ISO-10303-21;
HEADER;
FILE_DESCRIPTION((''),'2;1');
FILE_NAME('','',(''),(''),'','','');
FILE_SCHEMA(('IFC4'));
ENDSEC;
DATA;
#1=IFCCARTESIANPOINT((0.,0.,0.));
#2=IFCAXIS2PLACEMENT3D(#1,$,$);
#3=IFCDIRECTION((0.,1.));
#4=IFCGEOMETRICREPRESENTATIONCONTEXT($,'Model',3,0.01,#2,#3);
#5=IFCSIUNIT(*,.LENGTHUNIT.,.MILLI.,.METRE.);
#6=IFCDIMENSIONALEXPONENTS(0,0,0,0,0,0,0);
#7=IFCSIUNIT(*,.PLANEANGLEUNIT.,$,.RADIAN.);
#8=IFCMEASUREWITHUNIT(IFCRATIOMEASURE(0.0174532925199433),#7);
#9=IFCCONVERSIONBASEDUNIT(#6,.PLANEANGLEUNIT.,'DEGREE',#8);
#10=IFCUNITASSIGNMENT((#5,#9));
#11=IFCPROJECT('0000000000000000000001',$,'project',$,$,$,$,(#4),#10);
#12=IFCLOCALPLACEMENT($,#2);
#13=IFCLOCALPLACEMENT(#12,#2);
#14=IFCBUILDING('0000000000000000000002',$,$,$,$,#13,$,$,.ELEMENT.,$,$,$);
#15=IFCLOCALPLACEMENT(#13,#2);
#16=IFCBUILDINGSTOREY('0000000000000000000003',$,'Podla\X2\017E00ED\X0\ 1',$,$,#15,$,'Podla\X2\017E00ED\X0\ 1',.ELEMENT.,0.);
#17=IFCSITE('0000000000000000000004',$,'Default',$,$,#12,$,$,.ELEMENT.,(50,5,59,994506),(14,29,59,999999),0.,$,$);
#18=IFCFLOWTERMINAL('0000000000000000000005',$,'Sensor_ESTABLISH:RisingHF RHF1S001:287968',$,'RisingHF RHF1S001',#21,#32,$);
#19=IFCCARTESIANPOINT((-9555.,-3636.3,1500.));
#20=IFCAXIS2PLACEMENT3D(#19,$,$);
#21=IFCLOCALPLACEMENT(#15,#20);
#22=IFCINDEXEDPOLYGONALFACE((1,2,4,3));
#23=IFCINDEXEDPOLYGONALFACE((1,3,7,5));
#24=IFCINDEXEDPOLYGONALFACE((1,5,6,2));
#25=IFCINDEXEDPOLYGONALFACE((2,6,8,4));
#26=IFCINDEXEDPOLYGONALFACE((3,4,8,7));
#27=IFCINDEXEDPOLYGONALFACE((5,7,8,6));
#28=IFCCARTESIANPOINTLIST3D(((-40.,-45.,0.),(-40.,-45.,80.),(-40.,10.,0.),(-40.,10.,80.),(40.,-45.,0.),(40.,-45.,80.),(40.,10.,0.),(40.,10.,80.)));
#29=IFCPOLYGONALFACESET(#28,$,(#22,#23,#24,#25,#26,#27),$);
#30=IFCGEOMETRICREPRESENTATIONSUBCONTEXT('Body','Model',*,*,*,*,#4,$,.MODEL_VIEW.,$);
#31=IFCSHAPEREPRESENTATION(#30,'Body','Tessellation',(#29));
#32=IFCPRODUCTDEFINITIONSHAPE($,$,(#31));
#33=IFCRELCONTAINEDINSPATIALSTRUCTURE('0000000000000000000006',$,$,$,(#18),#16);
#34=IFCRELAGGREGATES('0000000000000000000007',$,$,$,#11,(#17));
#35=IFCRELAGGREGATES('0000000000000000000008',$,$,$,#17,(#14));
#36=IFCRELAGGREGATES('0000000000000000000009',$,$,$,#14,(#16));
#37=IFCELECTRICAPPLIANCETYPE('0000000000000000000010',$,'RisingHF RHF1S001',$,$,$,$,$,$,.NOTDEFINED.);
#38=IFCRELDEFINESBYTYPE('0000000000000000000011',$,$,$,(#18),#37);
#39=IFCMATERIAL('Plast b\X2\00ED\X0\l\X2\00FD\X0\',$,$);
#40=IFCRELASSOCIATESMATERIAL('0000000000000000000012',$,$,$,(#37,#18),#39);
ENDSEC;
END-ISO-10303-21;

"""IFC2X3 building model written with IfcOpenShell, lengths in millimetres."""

from ifc_helpers import new_model, entity, si_unit, converted_unit, direction, frame, frame_2d, origin, place, context, subcontext, project, spatial, rectangle, extrude, source, transform, mapped, material, type_object, type_shapes, element, save


model = new_model("IFC2X3")

# Units and contexts
model_context = context("Model", 3, precision=0.01, world=origin(), true_north=direction((0.0, 1.0)))
body_context = subcontext(model_context, "Body", "Model", "MODEL_VIEW")
ifc_project = project(units=[si_unit("LENGTHUNIT", "METRE", prefix="MILLI"), converted_unit("PLANEANGLEUNIT", "DEGREE", entity("IfcRatioMeasure", 0.0174532925199433), si_unit("PLANEANGLEUNIT", "RADIAN"), dimensions=[0, 0, 0, 0, 0, 0, 0])], contexts=[model_context])

# Site, building, storey
site_placement = place(None, origin())
site = spatial("IfcSite", under=ifc_project, at=site_placement, Name="Default", CompositionType="ELEMENT", RefLatitude=(50, 5, 59, 994506), RefLongitude=(14, 29, 59, 999999), RefElevation=0.0)
building_placement = place(site_placement, origin())
building = spatial("IfcBuilding", under=site, at=building_placement, CompositionType="ELEMENT")
storey_placement = place(building_placement, origin())
storey = spatial("IfcBuildingStorey", under=building, at=storey_placement, Name="Podlaží 1", LongName="Podlaží 1", CompositionType="ELEMENT", Elevation=0.0)

# Flow terminal
ifc_material_1 = material(Name="Plast bílý")
electric_appliance_type = type_object("IfcElectricApplianceType", Name="RisingHF RHF1S001", PredefinedType="NOTDEFINED", material=ifc_material_1)
shared_shape_1 = source(origin(), body_context, "Body", "SweptSolid", [
    extrude(rectangle(XDim=80.0, YDim=55.0, at=frame_2d((0.0, 0.0), x_axis=(1.0, 0.0))), frame((0.0, -17.5, 0.0), z_axis=(0.0, 0.0, 1.0), x_axis=(-1.0, 0.0, 0.0)), (0.0, 0.0, 1.0), 80.0),
])
type_shapes(electric_appliance_type, [shared_shape_1])
flow_terminal_placement = place(storey_placement, frame((-9555.0, -3636.3, 1500.0)))
element("IfcFlowTerminal", 1, at=flow_terminal_placement, inside=storey, type_object=electric_appliance_type, material=ifc_material_1, Name="Sensor_ESTABLISH:RisingHF RHF1S001:287968", ObjectType="RisingHF RHF1S001", context=body_context, shape_type="MappedRepresentation", body=[
    mapped(shared_shape_1, transform((0.0, 0.0, 0.0), scale=1.0)),
])

save(model, "model.ifc")
